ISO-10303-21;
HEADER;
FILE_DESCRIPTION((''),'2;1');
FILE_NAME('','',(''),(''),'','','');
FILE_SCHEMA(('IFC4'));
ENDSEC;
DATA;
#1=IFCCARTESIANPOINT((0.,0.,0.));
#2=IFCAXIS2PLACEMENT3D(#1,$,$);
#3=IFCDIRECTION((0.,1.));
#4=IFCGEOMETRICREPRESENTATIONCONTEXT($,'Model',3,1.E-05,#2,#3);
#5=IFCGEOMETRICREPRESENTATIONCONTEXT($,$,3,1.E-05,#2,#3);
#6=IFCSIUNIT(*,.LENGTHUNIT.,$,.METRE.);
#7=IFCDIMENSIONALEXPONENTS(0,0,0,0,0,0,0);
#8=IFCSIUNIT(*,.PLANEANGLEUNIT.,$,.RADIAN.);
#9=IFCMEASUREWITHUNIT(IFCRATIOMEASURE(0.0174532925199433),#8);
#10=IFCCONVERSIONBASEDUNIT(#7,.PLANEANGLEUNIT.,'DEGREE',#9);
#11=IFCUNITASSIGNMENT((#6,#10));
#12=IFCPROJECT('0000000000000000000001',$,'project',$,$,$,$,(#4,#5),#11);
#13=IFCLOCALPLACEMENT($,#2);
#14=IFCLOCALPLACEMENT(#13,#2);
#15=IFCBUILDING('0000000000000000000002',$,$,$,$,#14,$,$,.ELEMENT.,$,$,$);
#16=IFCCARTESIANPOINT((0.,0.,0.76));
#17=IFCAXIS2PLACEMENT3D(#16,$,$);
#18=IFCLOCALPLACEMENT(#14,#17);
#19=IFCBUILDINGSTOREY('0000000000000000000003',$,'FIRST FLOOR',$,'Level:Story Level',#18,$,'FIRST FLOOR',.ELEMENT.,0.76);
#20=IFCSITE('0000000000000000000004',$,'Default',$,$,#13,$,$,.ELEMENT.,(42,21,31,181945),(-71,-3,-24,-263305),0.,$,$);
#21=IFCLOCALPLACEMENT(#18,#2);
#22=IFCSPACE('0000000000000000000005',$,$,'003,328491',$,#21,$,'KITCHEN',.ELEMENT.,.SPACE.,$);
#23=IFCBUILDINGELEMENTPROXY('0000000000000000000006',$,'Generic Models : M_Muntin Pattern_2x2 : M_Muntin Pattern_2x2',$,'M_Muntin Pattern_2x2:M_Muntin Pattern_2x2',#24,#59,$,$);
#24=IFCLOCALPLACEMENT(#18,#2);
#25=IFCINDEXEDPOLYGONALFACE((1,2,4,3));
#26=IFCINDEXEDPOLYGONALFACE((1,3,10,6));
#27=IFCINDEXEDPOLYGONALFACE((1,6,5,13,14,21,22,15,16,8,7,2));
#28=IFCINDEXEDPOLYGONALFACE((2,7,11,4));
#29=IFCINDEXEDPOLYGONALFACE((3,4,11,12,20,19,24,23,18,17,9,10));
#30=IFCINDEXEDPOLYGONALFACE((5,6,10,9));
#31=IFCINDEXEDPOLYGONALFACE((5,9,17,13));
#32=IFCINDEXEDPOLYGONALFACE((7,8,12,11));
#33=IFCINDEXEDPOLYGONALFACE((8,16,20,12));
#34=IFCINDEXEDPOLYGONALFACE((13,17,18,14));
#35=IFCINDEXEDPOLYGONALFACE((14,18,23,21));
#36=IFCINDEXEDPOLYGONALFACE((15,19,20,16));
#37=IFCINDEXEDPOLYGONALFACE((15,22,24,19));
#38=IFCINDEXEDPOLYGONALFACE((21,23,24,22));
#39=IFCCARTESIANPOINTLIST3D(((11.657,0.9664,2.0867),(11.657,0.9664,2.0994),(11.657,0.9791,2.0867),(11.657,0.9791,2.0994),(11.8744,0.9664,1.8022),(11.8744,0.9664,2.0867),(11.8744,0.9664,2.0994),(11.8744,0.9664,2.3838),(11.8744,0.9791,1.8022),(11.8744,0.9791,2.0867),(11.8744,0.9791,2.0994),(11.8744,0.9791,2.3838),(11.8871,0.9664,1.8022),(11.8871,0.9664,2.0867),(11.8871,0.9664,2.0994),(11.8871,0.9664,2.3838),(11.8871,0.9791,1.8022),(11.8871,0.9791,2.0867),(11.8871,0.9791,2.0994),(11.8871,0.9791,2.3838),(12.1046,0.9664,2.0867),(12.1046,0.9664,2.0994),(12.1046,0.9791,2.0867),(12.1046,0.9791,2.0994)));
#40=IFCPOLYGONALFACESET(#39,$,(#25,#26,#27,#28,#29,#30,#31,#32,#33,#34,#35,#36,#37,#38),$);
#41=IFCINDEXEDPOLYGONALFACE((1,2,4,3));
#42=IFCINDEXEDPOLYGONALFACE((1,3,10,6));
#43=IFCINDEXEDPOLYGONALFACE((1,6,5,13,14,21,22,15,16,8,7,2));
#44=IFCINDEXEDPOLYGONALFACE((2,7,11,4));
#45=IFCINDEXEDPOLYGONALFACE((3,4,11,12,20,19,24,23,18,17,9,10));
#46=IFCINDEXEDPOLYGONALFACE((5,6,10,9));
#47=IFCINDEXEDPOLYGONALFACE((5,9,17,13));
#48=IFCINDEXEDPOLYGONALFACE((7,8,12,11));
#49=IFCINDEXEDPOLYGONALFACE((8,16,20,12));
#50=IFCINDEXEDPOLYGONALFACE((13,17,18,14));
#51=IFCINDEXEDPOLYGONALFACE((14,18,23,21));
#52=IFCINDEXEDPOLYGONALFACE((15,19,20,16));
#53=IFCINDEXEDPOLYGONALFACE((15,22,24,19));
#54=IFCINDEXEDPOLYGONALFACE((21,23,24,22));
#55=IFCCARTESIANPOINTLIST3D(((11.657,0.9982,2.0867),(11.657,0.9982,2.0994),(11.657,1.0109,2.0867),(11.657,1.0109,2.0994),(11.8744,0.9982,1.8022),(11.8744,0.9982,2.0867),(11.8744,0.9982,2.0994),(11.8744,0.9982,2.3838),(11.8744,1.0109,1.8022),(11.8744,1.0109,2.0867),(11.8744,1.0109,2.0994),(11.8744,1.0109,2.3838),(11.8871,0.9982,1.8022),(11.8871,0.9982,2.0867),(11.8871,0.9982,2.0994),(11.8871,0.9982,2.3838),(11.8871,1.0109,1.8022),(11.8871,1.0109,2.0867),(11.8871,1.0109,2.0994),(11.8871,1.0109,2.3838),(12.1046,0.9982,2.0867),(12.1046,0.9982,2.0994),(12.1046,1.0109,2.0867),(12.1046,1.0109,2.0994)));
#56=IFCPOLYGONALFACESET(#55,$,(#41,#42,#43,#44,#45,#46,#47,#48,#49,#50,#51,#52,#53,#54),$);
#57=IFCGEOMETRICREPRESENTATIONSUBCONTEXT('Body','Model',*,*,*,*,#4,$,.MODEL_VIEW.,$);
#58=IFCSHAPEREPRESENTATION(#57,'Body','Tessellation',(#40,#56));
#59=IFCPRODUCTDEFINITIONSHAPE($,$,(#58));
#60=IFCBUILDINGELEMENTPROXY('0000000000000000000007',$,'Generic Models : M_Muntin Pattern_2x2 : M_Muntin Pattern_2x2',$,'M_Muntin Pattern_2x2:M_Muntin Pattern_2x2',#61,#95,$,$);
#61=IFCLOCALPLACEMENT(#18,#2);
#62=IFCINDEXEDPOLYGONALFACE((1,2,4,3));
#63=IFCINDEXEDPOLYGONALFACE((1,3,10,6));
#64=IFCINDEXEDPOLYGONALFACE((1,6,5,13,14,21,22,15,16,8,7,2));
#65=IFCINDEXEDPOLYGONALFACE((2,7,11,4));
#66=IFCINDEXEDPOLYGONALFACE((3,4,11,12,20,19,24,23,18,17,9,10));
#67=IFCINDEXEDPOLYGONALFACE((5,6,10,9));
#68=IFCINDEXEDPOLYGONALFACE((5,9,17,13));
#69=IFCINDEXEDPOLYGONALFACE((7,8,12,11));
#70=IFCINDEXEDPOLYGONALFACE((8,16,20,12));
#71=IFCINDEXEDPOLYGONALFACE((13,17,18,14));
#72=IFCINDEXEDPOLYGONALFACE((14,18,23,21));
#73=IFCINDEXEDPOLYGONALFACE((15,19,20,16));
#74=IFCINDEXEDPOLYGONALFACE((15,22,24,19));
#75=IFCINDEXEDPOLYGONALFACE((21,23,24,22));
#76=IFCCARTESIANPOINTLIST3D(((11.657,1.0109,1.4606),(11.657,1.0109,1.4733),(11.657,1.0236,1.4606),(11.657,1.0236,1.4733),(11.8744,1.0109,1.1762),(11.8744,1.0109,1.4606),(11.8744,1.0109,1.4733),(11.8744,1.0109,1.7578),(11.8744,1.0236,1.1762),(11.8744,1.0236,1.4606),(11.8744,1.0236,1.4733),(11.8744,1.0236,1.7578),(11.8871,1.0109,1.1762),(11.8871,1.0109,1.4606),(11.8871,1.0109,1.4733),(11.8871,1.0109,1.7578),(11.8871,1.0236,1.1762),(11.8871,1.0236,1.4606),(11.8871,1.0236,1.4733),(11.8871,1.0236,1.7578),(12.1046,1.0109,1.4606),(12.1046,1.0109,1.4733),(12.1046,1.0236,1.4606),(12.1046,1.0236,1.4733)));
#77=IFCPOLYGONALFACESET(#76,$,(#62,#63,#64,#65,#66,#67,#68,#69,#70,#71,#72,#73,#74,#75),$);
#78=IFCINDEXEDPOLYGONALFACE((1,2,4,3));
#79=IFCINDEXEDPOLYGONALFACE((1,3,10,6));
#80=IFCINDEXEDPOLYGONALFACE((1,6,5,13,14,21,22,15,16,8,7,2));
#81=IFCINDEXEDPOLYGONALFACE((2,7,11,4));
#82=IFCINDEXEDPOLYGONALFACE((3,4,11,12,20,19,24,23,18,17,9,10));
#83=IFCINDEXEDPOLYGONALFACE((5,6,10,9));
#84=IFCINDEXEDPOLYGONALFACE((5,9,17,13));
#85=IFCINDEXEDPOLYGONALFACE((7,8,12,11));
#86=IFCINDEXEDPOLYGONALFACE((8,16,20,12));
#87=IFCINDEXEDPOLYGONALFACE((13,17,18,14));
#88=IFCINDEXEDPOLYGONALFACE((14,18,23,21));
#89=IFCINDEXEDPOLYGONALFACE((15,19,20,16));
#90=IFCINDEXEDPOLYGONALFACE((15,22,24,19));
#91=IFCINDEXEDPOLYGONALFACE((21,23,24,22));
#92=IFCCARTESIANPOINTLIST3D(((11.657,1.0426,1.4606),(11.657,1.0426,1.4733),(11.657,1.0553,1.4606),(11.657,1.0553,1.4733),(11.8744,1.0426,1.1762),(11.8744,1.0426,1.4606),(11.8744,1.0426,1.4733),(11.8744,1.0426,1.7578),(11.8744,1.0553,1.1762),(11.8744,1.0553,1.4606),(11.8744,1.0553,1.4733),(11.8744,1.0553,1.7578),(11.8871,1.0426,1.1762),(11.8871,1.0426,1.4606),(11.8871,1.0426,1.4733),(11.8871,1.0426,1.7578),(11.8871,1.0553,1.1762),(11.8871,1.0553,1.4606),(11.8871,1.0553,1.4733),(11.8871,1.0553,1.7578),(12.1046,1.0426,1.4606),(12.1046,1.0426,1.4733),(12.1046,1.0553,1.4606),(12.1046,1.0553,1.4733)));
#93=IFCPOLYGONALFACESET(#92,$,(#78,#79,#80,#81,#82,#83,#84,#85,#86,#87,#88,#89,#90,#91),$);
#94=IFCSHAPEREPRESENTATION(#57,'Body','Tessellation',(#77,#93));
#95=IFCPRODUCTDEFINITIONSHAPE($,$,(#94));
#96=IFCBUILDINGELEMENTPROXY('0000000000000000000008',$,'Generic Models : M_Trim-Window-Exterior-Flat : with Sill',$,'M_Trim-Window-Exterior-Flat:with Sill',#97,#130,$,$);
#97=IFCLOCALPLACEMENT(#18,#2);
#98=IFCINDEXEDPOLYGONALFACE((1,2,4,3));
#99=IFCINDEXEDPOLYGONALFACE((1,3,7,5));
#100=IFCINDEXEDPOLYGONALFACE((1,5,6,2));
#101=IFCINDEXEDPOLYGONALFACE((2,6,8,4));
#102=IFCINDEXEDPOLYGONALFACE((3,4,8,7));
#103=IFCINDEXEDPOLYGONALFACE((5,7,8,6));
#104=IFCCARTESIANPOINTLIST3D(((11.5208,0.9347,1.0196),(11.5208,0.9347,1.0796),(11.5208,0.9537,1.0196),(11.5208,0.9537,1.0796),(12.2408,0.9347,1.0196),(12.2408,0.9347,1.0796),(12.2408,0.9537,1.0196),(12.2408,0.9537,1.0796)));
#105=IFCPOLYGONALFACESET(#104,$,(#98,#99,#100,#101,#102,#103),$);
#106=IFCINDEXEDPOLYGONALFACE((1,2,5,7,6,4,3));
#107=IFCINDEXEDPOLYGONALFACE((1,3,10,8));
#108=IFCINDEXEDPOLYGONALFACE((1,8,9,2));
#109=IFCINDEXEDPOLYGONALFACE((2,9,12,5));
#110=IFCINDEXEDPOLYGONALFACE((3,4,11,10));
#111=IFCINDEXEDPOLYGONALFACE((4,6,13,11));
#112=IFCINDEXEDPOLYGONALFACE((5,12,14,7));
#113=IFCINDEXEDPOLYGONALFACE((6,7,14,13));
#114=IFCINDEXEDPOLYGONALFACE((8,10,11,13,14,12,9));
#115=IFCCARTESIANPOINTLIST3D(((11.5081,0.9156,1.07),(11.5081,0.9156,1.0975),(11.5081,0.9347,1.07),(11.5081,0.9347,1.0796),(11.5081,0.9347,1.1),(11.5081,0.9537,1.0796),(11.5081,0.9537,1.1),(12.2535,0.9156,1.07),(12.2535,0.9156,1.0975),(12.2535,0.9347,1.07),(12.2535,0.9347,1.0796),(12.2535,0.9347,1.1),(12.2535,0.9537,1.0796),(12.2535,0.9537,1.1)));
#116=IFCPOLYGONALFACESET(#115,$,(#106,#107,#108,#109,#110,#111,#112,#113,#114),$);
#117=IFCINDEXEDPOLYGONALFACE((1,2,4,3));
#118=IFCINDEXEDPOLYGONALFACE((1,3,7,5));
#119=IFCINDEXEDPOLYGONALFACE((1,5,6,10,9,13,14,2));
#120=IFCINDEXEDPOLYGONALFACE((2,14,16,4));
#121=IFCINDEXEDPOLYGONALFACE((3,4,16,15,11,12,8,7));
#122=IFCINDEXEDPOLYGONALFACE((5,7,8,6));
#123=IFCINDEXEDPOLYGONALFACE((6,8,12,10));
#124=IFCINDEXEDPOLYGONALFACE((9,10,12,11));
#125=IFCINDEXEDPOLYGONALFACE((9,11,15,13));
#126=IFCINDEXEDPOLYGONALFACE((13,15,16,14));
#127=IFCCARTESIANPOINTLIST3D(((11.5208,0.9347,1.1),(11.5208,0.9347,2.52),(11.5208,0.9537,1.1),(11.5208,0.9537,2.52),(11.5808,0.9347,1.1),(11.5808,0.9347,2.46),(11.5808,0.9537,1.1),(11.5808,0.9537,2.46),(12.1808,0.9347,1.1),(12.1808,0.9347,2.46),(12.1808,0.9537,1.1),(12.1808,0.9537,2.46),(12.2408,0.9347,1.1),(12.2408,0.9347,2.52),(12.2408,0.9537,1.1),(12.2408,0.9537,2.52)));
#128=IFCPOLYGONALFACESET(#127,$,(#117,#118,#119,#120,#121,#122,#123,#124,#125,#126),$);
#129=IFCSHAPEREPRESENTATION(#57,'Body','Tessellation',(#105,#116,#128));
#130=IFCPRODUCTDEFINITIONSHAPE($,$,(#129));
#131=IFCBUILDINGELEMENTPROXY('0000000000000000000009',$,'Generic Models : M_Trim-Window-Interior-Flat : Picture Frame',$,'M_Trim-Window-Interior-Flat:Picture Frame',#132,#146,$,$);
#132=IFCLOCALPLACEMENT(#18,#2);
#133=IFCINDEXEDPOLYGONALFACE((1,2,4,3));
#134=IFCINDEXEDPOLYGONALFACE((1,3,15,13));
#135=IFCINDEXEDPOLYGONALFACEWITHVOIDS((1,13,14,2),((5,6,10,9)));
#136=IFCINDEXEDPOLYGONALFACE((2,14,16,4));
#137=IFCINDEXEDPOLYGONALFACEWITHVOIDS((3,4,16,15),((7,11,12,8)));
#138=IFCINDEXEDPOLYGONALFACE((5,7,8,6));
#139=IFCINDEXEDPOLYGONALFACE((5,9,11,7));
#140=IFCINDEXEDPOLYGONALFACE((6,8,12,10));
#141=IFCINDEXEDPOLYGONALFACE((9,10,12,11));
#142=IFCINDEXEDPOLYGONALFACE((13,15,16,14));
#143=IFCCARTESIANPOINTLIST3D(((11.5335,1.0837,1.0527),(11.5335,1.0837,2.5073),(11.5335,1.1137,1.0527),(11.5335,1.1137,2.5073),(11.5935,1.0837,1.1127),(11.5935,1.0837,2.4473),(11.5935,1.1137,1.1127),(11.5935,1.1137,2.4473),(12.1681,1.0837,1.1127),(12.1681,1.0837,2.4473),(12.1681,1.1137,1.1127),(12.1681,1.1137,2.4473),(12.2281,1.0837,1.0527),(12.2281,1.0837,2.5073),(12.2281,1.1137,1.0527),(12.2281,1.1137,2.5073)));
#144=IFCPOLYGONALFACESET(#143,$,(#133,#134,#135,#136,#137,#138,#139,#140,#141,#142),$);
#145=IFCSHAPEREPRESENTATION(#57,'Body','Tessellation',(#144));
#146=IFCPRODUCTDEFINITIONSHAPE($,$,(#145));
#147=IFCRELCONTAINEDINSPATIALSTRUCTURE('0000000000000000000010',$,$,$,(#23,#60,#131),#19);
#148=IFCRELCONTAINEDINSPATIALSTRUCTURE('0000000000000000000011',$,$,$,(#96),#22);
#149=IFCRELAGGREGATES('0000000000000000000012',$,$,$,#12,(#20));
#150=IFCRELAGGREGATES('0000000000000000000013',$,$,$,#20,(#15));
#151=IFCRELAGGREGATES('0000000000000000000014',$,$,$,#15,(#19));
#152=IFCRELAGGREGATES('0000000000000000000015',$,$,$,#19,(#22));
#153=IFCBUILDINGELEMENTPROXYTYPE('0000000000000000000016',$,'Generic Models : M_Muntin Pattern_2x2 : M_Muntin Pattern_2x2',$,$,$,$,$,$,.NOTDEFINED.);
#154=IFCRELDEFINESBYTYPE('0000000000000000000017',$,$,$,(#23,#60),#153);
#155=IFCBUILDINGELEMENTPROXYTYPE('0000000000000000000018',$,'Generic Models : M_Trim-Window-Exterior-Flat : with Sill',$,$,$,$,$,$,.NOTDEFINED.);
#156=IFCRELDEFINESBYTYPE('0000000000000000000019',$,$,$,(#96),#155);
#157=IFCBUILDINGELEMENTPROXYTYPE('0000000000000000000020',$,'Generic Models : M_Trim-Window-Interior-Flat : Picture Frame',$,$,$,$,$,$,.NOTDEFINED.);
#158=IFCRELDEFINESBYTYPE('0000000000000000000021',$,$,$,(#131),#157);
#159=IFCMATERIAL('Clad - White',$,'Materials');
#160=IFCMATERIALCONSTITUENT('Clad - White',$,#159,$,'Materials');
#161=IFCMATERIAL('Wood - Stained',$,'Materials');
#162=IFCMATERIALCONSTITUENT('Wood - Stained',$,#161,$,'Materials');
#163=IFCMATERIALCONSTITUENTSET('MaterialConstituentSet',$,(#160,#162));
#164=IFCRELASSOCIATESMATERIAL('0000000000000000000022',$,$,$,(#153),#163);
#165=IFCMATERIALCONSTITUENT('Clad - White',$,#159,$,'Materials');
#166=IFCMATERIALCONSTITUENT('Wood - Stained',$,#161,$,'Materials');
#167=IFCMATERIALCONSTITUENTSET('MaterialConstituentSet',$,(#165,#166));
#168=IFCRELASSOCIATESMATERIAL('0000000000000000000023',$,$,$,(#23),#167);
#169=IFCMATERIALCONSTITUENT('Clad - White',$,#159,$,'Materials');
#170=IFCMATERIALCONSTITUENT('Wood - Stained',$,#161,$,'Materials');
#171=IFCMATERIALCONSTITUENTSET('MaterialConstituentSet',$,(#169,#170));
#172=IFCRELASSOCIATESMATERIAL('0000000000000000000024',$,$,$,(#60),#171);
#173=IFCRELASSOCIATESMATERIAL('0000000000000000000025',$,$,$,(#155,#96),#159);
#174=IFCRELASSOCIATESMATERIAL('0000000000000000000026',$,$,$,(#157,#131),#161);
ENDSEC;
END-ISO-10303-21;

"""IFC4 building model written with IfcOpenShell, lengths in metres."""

from ifc_helpers import new_model, entity, si_unit, converted_unit, direction, frame, frame_2d, origin, place, context, subcontext, project, spatial, polyline, rectangle, outline, extrude, source, transform, mapped, material, constituent, constituent_set, type_object, type_shapes, element, save


model = new_model("IFC4")

# Units and contexts
model_context = context("Model", 3, precision=1e-05, world=origin(), true_north=direction((0.0, 1.0)))
context_of_model = context(None, 3, precision=1e-05, world=origin(), true_north=direction((0.0, 1.0)))
body_context = subcontext(model_context, "Body", "Model", "MODEL_VIEW")
ifc_project = project(units=[si_unit("LENGTHUNIT", "METRE"), converted_unit("PLANEANGLEUNIT", "DEGREE", entity("IfcRatioMeasure", 0.0174532925199433), si_unit("PLANEANGLEUNIT", "RADIAN"), dimensions=[0, 0, 0, 0, 0, 0, 0])], contexts=[model_context, context_of_model])

# Site, building, storey
site_placement = place(None, origin())
site = spatial("IfcSite", under=ifc_project, at=site_placement, Name="Default", CompositionType="ELEMENT", RefLatitude=(42, 21, 31, 181945), RefLongitude=(-71, -3, -24, -263305), RefElevation=0.0)
building_placement = place(site_placement, origin())
building = spatial("IfcBuilding", under=site, at=building_placement, CompositionType="ELEMENT")
storey_placement = place(building_placement, frame((0.0, 0.0, 0.76)))
storey = spatial("IfcBuildingStorey", under=building, at=storey_placement, Name="FIRST FLOOR", ObjectType="Level:Story Level", LongName="FIRST FLOOR", CompositionType="ELEMENT", Elevation=0.76)

# Shared definitions
ifc_material_1 = material(Name="Wood - Stained", Category="Materials")

# Building element proxies
ifc_material_2 = material(Name="Clad - White", Category="Materials")
ifc_constituent_1 = constituent(ifc_material_2, Name="Clad - White", Category="Materials")
ifc_constituent_2 = constituent(ifc_material_1, Name="Wood - Stained", Category="Materials")
ifc_constituent_set_1 = constituent_set(constituents=[ifc_constituent_1, ifc_constituent_2], Name="MaterialConstituentSet")
ifc_constituent_3 = constituent(ifc_material_2, Name="Clad - White", Category="Materials")
ifc_constituent_4 = constituent(ifc_material_1, Name="Wood - Stained", Category="Materials")
ifc_constituent_set_2 = constituent_set(constituents=[ifc_constituent_3, ifc_constituent_4], Name="MaterialConstituentSet")
building_element_proxy_type_1 = type_object("IfcBuildingElementProxyType", Name="Generic Models : M_Muntin Pattern_2x2 : M_Muntin Pattern_2x2", PredefinedType="NOTDEFINED", material=ifc_constituent_set_2)
shared_shape_1 = source(origin(), body_context, "Body", "SweptSolid", [
    extrude(outline(polyline([(0.0064, -0.0064), (0.2908, -0.0064), (0.2908, 0.0063), (0.0064, 0.0063), (0.0064, 0.2238), (-0.0063, 0.2238), (-0.0063, 0.0063), (-0.2908, 0.0063), (-0.2908, -0.0064), (-0.0063, -0.0064), (-0.0063, -0.2238), (0.0064, -0.2238), (0.0064, -0.0064)])), frame((0.0, 0.0095, 0.2908), z_axis=(0.0, 1.0, 0.0), x_axis=(0.0, 0.0, 1.0)), (0.0, 0.0, 1.0), 0.0127),
    extrude(outline(polyline([(0.0064, -0.0064), (0.2908, -0.0064), (0.2908, 0.0063), (0.0064, 0.0063), (0.0064, 0.2238), (-0.0063, 0.2238), (-0.0063, 0.0063), (-0.2908, 0.0063), (-0.2908, -0.0064), (-0.0063, -0.0064), (-0.0063, -0.2238), (0.0064, -0.2238), (0.0064, -0.0064)])), frame((0.0, -0.0222, 0.2908), z_axis=(0.0, 1.0, 0.0), x_axis=(0.0, 0.0, 1.0)), (0.0, 0.0, 1.0), 0.0127),
])
type_shapes(building_element_proxy_type_1, [shared_shape_1])
proxy_1_placement = place(storey_placement, frame((11.8808, 0.9887, 1.8022), z_axis=(0.0, 0.0, 1.0), x_axis=(-1.0, 0.0, 0.0)))
element("IfcBuildingElementProxy", 1, at=proxy_1_placement, inside=storey, type_object=building_element_proxy_type_1, material=ifc_constituent_set_1, Name="Generic Models : M_Muntin Pattern_2x2 : M_Muntin Pattern_2x2", ObjectType="M_Muntin Pattern_2x2:M_Muntin Pattern_2x2", context=body_context, shape_type="MappedRepresentation", body=[
    mapped(shared_shape_1, transform((0.0, 0.0, 0.0), scale=1.0)),
])
ifc_constituent_5 = constituent(ifc_material_2, Name="Clad - White", Category="Materials")
ifc_constituent_6 = constituent(ifc_material_1, Name="Wood - Stained", Category="Materials")
ifc_constituent_set_3 = constituent_set(constituents=[ifc_constituent_5, ifc_constituent_6], Name="MaterialConstituentSet")
proxy_2_placement = place(storey_placement, frame((11.8808, 1.0331, 1.1762), z_axis=(0.0, 0.0, 1.0), x_axis=(-1.0, 0.0, 0.0)))
element("IfcBuildingElementProxy", 2, at=proxy_2_placement, inside=storey, type_object=building_element_proxy_type_1, material=ifc_constituent_set_3, Name="Generic Models : M_Muntin Pattern_2x2 : M_Muntin Pattern_2x2", ObjectType="M_Muntin Pattern_2x2:M_Muntin Pattern_2x2", context=body_context, shape_type="MappedRepresentation", body=[
    mapped(shared_shape_1, transform((0.0, 0.0, 0.0), scale=1.0)),
])

# Shared definitions
space_placement = place(storey_placement, origin())
space = spatial("IfcSpace", under=storey, at=space_placement, Description="003,328491", LongName="KITCHEN", CompositionType="ELEMENT", PredefinedType="SPACE")

# Building element proxies
building_element_proxy_type_2 = type_object("IfcBuildingElementProxyType", Name="Generic Models : M_Trim-Window-Exterior-Flat : with Sill", PredefinedType="NOTDEFINED", material=ifc_material_2)
shared_shape_2 = source(origin(), body_context, "Body", "SweptSolid", [
    extrude(rectangle(XDim=0.72, YDim=0.06, at=frame_2d((0.0, 0.0), x_axis=(1.0, 0.0))), frame((0.0, -1.4104, 0.0), z_axis=(0.0, 0.0, 1.0), x_axis=(-1.0, 0.0, 0.0)), (0.0, 0.0, 1.0), 0.0191),
    extrude(outline(polyline([(-0.019, -0.0152), (0.0, -0.0152), (0.0, -0.0057), (0.019, -0.0057), (0.019, 0.0148), (0.0, 0.0148), (-0.019, 0.0123), (-0.019, -0.0152)])), frame((-0.3727, -1.3748, 0.019), z_axis=(1.0, 0.0, 0.0), x_axis=(0.0, 0.0, -1.0)), (0.0, 0.0, 1.0), 0.7454),
    extrude(outline(polyline([(-0.725, -0.36), (0.695, -0.36), (0.695, -0.3), (-0.665, -0.3), (-0.665, 0.3), (0.695, 0.3), (0.695, 0.36), (-0.725, 0.36), (-0.725, -0.36)])), frame((0.0, -0.665, 0.0), z_axis=(0.0, 0.0, 1.0), x_axis=(0.0, -1.0, 0.0)), (0.0, 0.0, 1.0), 0.0191),
])
type_shapes(building_element_proxy_type_2, [shared_shape_2])
proxy_3_placement = place(space_placement, frame((11.8808, 0.9537, 2.46), z_axis=(0.0, -1.0, 0.0), x_axis=(1.0, 0.0, 0.0)))
element("IfcBuildingElementProxy", 3, at=proxy_3_placement, inside=space, type_object=building_element_proxy_type_2, material=ifc_material_2, Name="Generic Models : M_Trim-Window-Exterior-Flat : with Sill", ObjectType="M_Trim-Window-Exterior-Flat:with Sill", context=body_context, shape_type="MappedRepresentation", body=[
    mapped(shared_shape_2, transform((0.0, 0.0, 0.0), scale=1.0)),
])
building_element_proxy_type_3 = type_object("IfcBuildingElementProxyType", Name="Generic Models : M_Trim-Window-Interior-Flat : Picture Frame", PredefinedType="NOTDEFINED", material=ifc_material_1)
shared_shape_3 = source(origin(), body_context, "Body", "SweptSolid", [
    extrude(outline(polyline([(-0.3473, -0.7273), (0.3473, -0.7273), (0.3473, 0.7273), (-0.3473, 0.7273), (-0.3473, -0.7273)]), holes=[polyline([(-0.2873, -0.6673), (-0.2873, 0.6673), (0.2873, 0.6673), (0.2873, -0.6673), (-0.2873, -0.6673)])]), frame((0.0, -0.68, 0.0), z_axis=(0.0, 0.0, 1.0), x_axis=(-1.0, 0.0, 0.0)), (0.0, 0.0, 1.0), 0.03),
])
type_shapes(building_element_proxy_type_3, [shared_shape_3])
proxy_4_placement = place(storey_placement, frame((11.8808, 1.0837, 2.46), z_axis=(0.0, 1.0, 0.0), x_axis=(-1.0, 0.0, 0.0)))
element("IfcBuildingElementProxy", 4, at=proxy_4_placement, inside=storey, type_object=building_element_proxy_type_3, material=ifc_material_1, Name="Generic Models : M_Trim-Window-Interior-Flat : Picture Frame", ObjectType="M_Trim-Window-Interior-Flat:Picture Frame", context=body_context, shape_type="MappedRepresentation", body=[
    mapped(shared_shape_3, transform((0.0, 0.0, 0.0), scale=1.0)),
])

save(model, "model.ifc")
